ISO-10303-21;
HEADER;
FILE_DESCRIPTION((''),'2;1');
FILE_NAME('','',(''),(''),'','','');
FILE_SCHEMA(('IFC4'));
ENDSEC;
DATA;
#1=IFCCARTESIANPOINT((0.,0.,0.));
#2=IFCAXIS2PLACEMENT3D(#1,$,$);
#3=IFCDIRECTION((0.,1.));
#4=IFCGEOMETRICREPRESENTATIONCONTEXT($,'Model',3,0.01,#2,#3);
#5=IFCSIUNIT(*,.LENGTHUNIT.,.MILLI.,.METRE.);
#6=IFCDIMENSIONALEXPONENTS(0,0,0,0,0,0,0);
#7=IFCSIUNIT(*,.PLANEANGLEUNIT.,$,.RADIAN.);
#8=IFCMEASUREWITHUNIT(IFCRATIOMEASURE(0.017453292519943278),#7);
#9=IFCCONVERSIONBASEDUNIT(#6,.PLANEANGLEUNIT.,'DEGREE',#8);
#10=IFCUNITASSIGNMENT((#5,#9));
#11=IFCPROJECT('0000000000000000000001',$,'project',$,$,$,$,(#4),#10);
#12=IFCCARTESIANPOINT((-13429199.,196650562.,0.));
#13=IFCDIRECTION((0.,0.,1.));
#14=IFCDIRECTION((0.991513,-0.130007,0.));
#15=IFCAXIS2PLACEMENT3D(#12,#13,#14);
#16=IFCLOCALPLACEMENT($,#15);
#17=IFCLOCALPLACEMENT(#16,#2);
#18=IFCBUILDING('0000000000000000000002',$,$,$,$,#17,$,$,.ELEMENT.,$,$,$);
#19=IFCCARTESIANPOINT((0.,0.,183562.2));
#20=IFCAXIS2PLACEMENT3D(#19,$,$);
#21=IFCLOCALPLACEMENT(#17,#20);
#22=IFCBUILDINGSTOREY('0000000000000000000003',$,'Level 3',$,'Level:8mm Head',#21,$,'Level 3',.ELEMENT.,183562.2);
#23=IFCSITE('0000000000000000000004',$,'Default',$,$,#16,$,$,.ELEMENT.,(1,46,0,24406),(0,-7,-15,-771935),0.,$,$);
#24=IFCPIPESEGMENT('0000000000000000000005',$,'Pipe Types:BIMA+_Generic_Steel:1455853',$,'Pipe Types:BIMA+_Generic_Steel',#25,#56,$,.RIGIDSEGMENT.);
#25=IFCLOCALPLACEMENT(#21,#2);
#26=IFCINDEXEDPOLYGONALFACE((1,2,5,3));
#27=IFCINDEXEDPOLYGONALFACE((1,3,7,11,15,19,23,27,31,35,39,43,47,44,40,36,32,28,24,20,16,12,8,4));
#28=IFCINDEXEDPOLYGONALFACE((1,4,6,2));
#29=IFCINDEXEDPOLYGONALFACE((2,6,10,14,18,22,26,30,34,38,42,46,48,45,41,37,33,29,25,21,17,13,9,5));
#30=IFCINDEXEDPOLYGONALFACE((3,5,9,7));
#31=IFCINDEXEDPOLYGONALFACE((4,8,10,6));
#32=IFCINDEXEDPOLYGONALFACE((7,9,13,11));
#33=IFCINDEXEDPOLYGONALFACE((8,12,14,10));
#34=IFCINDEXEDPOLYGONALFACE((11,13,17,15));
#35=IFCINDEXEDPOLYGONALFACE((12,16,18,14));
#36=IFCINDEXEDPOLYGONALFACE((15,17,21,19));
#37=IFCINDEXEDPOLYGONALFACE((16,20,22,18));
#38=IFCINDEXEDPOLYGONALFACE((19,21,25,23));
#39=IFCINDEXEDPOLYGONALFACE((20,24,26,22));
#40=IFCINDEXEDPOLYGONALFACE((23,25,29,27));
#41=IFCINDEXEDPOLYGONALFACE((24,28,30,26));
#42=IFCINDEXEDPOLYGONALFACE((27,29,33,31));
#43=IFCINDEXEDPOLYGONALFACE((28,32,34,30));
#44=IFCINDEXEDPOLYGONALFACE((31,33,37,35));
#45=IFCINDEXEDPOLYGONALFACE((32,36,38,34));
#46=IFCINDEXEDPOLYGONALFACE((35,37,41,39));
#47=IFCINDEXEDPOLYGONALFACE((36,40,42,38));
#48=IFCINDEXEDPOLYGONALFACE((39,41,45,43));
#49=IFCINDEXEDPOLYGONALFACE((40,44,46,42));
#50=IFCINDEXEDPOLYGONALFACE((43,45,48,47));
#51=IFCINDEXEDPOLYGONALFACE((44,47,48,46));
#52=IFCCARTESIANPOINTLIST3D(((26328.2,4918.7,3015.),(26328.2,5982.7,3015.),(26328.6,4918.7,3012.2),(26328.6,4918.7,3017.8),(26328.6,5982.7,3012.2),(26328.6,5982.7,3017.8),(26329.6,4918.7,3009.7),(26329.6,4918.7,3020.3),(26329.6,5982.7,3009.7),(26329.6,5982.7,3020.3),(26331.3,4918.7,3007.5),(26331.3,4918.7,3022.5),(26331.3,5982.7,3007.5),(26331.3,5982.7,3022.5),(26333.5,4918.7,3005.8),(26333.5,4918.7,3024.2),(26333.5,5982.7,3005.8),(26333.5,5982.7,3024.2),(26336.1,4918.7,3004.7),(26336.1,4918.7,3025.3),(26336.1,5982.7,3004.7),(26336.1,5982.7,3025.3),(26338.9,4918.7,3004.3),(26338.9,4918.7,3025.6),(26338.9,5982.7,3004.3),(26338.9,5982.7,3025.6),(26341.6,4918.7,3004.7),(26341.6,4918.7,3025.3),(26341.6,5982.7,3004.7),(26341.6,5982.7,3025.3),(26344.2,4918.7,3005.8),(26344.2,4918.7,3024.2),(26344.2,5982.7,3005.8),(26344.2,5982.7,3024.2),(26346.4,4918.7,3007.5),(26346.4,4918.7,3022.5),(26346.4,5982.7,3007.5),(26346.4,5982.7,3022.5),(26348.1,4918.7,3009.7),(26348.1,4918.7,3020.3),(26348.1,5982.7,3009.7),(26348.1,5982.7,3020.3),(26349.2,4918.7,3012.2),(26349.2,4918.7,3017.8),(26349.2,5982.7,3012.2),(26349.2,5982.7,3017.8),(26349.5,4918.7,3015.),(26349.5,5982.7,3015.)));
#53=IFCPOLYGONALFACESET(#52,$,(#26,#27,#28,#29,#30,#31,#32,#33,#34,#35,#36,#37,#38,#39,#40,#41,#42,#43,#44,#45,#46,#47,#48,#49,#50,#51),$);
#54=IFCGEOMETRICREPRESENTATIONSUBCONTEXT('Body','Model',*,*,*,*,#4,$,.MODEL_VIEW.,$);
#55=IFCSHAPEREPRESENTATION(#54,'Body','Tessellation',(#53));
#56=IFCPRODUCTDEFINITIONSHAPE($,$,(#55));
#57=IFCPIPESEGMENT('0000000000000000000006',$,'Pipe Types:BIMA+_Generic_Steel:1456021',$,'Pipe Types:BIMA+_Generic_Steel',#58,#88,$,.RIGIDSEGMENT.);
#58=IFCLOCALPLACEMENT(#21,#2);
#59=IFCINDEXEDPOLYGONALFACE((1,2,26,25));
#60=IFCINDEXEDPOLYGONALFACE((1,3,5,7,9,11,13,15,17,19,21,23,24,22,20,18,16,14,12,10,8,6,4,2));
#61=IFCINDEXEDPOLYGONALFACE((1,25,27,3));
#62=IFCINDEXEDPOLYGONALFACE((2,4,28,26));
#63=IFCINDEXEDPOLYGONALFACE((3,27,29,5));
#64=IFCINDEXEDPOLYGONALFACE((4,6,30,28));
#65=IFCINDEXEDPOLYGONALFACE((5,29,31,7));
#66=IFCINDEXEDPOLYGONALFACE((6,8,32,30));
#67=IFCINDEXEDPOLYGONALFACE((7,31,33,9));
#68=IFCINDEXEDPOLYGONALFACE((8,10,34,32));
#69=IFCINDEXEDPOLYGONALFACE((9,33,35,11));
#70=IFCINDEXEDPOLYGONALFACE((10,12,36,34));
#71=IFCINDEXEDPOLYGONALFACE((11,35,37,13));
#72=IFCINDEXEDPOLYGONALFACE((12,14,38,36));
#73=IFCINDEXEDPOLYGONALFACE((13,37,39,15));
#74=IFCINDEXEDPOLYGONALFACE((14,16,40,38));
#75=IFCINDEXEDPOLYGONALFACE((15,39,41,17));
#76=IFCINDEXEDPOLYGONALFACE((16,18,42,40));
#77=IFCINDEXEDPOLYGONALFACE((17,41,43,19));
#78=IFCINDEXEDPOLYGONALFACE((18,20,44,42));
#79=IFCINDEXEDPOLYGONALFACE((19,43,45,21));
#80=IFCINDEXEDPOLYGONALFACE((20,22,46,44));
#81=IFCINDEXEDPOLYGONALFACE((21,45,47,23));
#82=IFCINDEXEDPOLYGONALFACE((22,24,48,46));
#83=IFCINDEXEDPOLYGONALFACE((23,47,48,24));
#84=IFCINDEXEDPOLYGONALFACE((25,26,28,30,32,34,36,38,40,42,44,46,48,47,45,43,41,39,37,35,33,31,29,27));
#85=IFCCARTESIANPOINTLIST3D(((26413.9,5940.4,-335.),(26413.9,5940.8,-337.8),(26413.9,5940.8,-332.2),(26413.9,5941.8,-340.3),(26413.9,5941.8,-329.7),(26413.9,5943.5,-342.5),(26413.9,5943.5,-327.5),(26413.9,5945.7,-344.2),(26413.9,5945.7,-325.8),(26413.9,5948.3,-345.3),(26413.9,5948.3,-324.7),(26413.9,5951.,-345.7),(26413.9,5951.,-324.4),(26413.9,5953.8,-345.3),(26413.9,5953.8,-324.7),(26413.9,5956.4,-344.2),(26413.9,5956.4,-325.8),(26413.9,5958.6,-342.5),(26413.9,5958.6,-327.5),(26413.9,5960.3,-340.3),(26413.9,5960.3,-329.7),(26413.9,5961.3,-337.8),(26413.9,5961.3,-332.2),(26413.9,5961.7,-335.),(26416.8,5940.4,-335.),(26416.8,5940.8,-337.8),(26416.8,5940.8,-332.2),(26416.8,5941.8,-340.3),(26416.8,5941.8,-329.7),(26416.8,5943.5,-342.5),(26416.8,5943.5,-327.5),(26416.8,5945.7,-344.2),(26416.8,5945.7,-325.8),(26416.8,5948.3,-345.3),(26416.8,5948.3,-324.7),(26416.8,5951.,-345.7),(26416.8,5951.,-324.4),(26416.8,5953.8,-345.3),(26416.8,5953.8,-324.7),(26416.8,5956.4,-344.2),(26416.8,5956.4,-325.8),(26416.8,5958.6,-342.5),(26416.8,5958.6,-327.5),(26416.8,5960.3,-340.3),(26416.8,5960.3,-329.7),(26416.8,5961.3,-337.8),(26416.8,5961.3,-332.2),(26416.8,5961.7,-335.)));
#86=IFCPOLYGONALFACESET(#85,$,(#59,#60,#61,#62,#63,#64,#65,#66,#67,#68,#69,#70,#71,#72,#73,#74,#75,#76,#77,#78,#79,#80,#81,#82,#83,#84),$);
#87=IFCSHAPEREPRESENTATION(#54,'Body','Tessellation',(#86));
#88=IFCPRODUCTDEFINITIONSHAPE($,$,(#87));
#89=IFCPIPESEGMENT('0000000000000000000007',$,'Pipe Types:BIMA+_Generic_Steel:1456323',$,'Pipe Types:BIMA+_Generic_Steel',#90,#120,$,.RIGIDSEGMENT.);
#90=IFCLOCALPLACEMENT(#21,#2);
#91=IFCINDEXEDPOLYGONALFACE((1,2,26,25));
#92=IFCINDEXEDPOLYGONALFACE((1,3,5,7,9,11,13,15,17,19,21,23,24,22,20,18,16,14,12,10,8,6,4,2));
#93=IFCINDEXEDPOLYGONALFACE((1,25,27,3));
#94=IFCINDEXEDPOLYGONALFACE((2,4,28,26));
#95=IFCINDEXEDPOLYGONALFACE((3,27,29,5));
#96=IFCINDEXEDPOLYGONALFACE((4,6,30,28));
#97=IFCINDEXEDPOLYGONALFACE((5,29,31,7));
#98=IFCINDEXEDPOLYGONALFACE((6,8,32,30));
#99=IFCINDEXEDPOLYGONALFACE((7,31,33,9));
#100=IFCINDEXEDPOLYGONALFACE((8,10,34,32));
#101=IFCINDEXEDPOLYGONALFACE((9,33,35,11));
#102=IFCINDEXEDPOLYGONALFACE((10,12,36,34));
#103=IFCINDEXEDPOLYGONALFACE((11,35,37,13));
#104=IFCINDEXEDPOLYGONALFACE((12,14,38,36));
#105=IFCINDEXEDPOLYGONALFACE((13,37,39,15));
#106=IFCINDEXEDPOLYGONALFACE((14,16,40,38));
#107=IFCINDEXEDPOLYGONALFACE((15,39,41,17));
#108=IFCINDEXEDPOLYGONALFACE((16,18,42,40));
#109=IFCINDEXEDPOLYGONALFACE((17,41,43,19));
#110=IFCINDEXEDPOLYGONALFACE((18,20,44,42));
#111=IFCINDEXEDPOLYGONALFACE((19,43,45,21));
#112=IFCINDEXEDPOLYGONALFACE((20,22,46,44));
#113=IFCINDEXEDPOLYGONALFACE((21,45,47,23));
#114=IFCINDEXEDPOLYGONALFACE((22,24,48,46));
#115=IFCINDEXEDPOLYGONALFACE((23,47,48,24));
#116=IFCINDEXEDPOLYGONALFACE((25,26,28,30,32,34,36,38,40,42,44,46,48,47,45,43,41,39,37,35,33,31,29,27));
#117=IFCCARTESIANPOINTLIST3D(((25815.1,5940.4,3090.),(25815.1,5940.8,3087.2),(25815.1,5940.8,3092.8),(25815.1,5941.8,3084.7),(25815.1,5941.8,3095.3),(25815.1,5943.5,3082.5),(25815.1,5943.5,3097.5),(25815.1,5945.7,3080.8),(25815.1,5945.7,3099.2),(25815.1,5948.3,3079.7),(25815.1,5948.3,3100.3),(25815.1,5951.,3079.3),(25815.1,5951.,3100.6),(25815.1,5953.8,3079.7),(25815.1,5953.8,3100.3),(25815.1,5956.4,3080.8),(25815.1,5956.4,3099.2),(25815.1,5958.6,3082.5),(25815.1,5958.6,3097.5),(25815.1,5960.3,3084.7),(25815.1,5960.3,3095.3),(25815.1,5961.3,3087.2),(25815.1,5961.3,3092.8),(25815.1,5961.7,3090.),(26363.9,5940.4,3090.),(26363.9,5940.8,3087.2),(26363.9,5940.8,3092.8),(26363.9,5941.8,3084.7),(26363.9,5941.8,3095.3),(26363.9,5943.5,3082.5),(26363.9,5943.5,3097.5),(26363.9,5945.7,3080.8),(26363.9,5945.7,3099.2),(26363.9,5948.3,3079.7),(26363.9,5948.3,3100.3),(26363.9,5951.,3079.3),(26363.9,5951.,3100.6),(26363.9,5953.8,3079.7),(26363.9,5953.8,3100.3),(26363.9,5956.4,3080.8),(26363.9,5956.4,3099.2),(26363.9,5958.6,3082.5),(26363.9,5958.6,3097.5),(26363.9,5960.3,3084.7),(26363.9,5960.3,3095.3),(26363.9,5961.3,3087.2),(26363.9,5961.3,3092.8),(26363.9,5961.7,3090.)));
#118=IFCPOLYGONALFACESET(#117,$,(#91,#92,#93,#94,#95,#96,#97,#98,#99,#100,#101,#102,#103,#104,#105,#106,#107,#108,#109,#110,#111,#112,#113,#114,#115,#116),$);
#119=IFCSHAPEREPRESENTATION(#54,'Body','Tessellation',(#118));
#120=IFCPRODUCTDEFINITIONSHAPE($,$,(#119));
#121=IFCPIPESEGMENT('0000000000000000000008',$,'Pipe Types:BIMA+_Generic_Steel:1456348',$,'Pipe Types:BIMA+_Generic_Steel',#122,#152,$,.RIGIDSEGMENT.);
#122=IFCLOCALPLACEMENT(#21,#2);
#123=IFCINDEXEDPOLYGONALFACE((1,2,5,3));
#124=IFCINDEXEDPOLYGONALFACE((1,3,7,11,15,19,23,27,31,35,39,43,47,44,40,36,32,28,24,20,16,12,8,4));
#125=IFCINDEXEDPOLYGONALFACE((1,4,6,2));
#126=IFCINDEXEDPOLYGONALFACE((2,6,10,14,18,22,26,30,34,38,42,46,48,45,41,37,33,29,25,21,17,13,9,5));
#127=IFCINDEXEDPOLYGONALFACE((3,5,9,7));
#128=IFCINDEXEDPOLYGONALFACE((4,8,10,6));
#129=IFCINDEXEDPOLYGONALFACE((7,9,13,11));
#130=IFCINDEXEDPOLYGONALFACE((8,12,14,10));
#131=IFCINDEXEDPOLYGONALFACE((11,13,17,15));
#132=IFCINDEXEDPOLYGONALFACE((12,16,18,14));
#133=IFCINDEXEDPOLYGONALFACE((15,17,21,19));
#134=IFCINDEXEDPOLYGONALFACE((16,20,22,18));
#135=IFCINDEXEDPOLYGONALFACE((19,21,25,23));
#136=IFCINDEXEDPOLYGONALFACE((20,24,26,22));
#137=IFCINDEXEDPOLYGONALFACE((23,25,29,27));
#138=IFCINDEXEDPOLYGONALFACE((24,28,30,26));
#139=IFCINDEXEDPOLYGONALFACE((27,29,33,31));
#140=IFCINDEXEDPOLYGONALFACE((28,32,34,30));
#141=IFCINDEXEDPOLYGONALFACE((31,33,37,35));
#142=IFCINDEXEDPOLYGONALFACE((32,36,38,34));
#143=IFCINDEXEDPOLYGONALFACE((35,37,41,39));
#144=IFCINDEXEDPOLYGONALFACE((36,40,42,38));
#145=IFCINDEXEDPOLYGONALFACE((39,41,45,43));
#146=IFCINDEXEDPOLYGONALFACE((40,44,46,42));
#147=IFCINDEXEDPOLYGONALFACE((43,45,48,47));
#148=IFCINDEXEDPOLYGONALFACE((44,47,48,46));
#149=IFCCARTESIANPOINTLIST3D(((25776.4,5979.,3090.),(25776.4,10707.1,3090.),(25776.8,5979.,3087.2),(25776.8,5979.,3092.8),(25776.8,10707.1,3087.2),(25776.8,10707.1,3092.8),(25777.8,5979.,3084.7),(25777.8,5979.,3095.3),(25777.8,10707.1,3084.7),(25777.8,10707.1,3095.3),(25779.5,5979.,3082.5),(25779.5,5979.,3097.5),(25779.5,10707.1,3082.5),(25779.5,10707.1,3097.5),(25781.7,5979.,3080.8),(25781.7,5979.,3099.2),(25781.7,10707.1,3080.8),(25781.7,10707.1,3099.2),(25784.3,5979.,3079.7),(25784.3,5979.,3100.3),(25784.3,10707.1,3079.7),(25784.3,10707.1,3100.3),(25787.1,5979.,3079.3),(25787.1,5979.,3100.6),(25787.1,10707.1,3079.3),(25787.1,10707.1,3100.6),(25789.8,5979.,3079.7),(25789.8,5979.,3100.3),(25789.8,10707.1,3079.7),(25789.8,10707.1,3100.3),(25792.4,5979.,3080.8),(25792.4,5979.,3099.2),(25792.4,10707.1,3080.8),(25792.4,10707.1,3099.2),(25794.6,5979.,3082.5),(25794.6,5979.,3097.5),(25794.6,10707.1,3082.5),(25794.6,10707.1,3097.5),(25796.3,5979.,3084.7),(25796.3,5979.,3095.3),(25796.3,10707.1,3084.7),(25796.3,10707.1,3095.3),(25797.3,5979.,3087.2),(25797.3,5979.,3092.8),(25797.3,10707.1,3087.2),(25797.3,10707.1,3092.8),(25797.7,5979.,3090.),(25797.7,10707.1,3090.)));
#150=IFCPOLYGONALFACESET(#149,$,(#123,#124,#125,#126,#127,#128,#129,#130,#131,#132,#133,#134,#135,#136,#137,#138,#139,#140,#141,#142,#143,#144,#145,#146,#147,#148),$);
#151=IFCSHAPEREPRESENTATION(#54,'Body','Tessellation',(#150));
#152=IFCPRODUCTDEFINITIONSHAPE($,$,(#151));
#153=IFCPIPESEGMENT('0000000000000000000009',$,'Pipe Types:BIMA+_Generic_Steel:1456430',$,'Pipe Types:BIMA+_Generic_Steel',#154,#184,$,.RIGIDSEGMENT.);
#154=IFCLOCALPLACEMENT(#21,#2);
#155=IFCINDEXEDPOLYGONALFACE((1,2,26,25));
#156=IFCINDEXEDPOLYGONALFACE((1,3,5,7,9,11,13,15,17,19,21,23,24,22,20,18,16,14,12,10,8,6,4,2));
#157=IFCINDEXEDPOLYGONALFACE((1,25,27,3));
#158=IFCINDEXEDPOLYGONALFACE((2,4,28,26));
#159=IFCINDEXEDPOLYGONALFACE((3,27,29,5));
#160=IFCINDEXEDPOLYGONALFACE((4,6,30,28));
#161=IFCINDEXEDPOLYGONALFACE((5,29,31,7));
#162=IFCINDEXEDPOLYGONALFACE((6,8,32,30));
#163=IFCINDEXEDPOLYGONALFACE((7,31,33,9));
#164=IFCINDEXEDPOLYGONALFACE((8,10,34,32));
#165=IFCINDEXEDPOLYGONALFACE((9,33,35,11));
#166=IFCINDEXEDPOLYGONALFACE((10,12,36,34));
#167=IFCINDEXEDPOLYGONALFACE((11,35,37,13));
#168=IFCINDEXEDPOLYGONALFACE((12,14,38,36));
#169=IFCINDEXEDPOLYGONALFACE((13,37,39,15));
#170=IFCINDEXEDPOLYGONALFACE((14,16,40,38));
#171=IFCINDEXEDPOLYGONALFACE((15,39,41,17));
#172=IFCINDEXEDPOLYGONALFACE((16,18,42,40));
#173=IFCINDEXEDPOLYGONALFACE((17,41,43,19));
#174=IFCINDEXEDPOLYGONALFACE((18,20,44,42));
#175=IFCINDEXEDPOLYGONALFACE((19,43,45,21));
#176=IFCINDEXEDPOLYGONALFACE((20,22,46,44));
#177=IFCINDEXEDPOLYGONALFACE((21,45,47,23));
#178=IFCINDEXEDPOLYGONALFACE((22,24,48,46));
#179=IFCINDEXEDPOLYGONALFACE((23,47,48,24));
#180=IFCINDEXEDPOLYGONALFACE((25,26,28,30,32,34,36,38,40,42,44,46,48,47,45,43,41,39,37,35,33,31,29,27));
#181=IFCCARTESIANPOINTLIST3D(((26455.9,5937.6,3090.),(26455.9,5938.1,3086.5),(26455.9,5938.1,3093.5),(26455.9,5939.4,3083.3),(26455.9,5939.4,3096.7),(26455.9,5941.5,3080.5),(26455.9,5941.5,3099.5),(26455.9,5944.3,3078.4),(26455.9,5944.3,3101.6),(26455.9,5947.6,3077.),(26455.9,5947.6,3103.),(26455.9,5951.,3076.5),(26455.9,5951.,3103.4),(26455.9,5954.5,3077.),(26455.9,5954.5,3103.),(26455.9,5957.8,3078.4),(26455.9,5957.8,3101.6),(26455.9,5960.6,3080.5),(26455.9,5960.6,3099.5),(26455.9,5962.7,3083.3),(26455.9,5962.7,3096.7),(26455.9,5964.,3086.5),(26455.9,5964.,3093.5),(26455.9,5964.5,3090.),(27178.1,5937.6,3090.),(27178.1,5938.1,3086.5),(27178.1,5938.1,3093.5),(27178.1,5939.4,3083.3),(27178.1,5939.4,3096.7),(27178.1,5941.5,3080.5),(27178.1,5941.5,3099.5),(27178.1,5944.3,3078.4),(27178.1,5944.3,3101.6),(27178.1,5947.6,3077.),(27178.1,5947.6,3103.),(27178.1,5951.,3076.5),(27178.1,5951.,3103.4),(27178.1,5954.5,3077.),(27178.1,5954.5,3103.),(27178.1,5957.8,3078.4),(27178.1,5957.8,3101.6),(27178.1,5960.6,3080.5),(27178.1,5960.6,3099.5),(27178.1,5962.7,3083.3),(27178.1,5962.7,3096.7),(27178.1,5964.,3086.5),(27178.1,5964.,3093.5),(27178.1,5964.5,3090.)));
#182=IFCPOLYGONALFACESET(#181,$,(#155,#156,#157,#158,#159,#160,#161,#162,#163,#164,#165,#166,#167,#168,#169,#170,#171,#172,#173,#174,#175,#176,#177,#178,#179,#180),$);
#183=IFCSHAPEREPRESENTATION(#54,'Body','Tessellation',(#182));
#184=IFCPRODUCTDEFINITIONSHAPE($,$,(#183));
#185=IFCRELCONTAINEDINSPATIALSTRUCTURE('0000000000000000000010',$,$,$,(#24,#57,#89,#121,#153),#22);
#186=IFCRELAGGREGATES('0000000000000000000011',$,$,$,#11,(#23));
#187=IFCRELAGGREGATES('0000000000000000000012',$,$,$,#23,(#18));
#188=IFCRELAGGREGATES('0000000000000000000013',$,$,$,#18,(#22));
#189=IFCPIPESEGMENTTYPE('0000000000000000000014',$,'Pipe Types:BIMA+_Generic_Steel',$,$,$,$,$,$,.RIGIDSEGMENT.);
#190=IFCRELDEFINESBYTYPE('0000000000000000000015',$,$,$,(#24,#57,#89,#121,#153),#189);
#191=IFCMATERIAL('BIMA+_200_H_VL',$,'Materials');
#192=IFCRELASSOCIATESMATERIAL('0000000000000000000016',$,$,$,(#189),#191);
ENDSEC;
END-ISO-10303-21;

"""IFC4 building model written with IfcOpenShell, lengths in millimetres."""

from ifc_helpers import new_model, entity, si_unit, converted_unit, direction, frame, origin, place, context, subcontext, project, spatial, arc, indexed_curve, outline, extrude, material, type_object, element, save


model = new_model("IFC4")

# Units and contexts
model_context = context("Model", 3, precision=0.01, world=origin(), true_north=direction((0.0, 1.0)))
body_context = subcontext(model_context, "Body", "Model", "MODEL_VIEW")
ifc_project = project(units=[si_unit("LENGTHUNIT", "METRE", prefix="MILLI"), converted_unit("PLANEANGLEUNIT", "DEGREE", entity("IfcRatioMeasure", 0.017453292519943278), si_unit("PLANEANGLEUNIT", "RADIAN"), dimensions=[0, 0, 0, 0, 0, 0, 0])], contexts=[model_context])

# Site, building, storey
site_placement = place(None, frame((-13429199.0, 196650562.0, 0.0), z_axis=(0.0, 0.0, 1.0), x_axis=(0.991513, -0.130007, 0.0)))
site = spatial("IfcSite", under=ifc_project, at=site_placement, Name="Default", CompositionType="ELEMENT", RefLatitude=(1, 46, 0, 24406), RefLongitude=(0, -7, -15, -771935), RefElevation=0.0)
building_placement = place(site_placement, origin())
building = spatial("IfcBuilding", under=site, at=building_placement, CompositionType="ELEMENT")
storey_placement = place(building_placement, frame((0.0, 0.0, 183562.2)))
storey = spatial("IfcBuildingStorey", under=building, at=storey_placement, Name="Level 3", ObjectType="Level:8mm Head", LongName="Level 3", CompositionType="ELEMENT", Elevation=183562.2)

# Pipe segments
ifc_material_1 = material(Name="BIMA+_200_H_VL", Category="Materials")
pipe_segment_type = type_object("IfcPipeSegmentType", Name="Pipe Types:BIMA+_Generic_Steel", PredefinedType="RIGIDSEGMENT", material=ifc_material_1)
pipe_segment_1_placement = place(storey_placement, frame((26326.6, 4918.7, 3002.8)))
element("IfcPipeSegment", 1, at=pipe_segment_1_placement, inside=storey, type_object=pipe_segment_type, Name="Pipe Types:BIMA+_Generic_Steel:1455853", ObjectType="Pipe Types:BIMA+_Generic_Steel", PredefinedType="RIGIDSEGMENT", context=body_context, shape_type="SweptSolid", body=[
    extrude(outline(indexed_curve([(10.7, 0.0), (7.5, 7.5), (0.0, 10.7), (-7.5, 7.5), (-10.7, 0.0), (-7.5, -7.5), (0.0, -10.7), (7.5, -7.5)], segments=[arc(1, 2, 3), arc(3, 4, 5), arc(5, 6, 7), arc(7, 8, 1)], self_intersect=False)), frame((12.2, 0.0, 12.2), z_axis=(0.0, 1.0, 0.0), x_axis=(-1.0, 0.0, 0.0)), (0.0, 0.0, 1.0), 1064.0),
])
pipe_segment_2_placement = place(storey_placement, frame((26413.9, 5938.8, -347.2)))
element("IfcPipeSegment", 2, at=pipe_segment_2_placement, inside=storey, type_object=pipe_segment_type, Name="Pipe Types:BIMA+_Generic_Steel:1456021", ObjectType="Pipe Types:BIMA+_Generic_Steel", PredefinedType="RIGIDSEGMENT", context=body_context, shape_type="SweptSolid", body=[
    extrude(outline(indexed_curve([(10.6, 0.0), (7.5, 7.5), (0.0, 10.7), (-7.5, 7.5), (-10.6, 0.0), (-7.5, -7.5), (0.0, -10.7), (7.5, -7.5)], segments=[arc(1, 2, 3), arc(3, 4, 5), arc(5, 6, 7), arc(7, 8, 1)], self_intersect=False)), frame((0.0, 12.2, 12.2), z_axis=(1.0, 0.0, 0.0), x_axis=(0.0, 1.0, 0.0)), (0.0, 0.0, 1.0), 2.9),
])
pipe_segment_3_placement = place(storey_placement, frame((25815.1, 5938.8, 3077.8)))
element("IfcPipeSegment", 3, at=pipe_segment_3_placement, inside=storey, type_object=pipe_segment_type, Name="Pipe Types:BIMA+_Generic_Steel:1456323", ObjectType="Pipe Types:BIMA+_Generic_Steel", PredefinedType="RIGIDSEGMENT", context=body_context, shape_type="SweptSolid", body=[
    extrude(outline(indexed_curve([(10.6, 0.0), (7.5, 7.5), (0.0, 10.7), (-7.5, 7.5), (-10.6, 0.0), (-7.5, -7.5), (0.0, -10.7), (7.5, -7.5)], segments=[arc(1, 2, 3), arc(3, 4, 5), arc(5, 6, 7), arc(7, 8, 1)], self_intersect=False)), frame((0.0, 12.2, 12.2), z_axis=(1.0, 0.0, 0.0), x_axis=(0.0, -1.0, 0.0)), (0.0, 0.0, 1.0), 548.8),
])
pipe_segment_4_placement = place(storey_placement, frame((25774.8, 5979.0, 3102.2)))
element("IfcPipeSegment", 4, at=pipe_segment_4_placement, inside=storey, type_object=pipe_segment_type, Name="Pipe Types:BIMA+_Generic_Steel:1456348", ObjectType="Pipe Types:BIMA+_Generic_Steel", PredefinedType="RIGIDSEGMENT", context=body_context, shape_type="SweptSolid", body=[
    extrude(outline(indexed_curve([(10.7, 0.0), (7.5, 7.5), (0.0, 10.7), (-7.5, 7.5), (-10.6, 0.0), (-7.5, -7.5), (0.0, -10.6), (7.5, -7.5)], segments=[arc(1, 2, 3), arc(3, 4, 5), arc(5, 6, 7), arc(7, 8, 1)], self_intersect=False)), frame((12.2, 0.0, -12.2), z_axis=(0.0, 1.0, 0.0), x_axis=(-1.0, 0.0, 0.0)), (0.0, 0.0, 1.0), 4728.1),
])
pipe_segment_5_placement = place(storey_placement, frame((26455.9, 5936.0, 3105.0)))
element("IfcPipeSegment", 5, at=pipe_segment_5_placement, inside=storey, type_object=pipe_segment_type, Name="Pipe Types:BIMA+_Generic_Steel:1456430", ObjectType="Pipe Types:BIMA+_Generic_Steel", PredefinedType="RIGIDSEGMENT", context=body_context, shape_type="SweptSolid", body=[
    extrude(outline(indexed_curve([(13.5, 0.0), (9.5, 9.5), (0.0, 13.5), (-9.5, 9.5), (-13.4, 0.0), (-9.5, -9.5), (0.0, -13.5), (9.5, -9.5)], segments=[arc(1, 2, 3), arc(3, 4, 5), arc(5, 6, 7), arc(7, 8, 1)], self_intersect=False)), frame((0.0, 15.0, -15.0), z_axis=(1.0, 0.0, 0.0), x_axis=(0.0, 1.0, 0.0)), (0.0, 0.0, 1.0), 722.2),
])

save(model, "model.ifc")
